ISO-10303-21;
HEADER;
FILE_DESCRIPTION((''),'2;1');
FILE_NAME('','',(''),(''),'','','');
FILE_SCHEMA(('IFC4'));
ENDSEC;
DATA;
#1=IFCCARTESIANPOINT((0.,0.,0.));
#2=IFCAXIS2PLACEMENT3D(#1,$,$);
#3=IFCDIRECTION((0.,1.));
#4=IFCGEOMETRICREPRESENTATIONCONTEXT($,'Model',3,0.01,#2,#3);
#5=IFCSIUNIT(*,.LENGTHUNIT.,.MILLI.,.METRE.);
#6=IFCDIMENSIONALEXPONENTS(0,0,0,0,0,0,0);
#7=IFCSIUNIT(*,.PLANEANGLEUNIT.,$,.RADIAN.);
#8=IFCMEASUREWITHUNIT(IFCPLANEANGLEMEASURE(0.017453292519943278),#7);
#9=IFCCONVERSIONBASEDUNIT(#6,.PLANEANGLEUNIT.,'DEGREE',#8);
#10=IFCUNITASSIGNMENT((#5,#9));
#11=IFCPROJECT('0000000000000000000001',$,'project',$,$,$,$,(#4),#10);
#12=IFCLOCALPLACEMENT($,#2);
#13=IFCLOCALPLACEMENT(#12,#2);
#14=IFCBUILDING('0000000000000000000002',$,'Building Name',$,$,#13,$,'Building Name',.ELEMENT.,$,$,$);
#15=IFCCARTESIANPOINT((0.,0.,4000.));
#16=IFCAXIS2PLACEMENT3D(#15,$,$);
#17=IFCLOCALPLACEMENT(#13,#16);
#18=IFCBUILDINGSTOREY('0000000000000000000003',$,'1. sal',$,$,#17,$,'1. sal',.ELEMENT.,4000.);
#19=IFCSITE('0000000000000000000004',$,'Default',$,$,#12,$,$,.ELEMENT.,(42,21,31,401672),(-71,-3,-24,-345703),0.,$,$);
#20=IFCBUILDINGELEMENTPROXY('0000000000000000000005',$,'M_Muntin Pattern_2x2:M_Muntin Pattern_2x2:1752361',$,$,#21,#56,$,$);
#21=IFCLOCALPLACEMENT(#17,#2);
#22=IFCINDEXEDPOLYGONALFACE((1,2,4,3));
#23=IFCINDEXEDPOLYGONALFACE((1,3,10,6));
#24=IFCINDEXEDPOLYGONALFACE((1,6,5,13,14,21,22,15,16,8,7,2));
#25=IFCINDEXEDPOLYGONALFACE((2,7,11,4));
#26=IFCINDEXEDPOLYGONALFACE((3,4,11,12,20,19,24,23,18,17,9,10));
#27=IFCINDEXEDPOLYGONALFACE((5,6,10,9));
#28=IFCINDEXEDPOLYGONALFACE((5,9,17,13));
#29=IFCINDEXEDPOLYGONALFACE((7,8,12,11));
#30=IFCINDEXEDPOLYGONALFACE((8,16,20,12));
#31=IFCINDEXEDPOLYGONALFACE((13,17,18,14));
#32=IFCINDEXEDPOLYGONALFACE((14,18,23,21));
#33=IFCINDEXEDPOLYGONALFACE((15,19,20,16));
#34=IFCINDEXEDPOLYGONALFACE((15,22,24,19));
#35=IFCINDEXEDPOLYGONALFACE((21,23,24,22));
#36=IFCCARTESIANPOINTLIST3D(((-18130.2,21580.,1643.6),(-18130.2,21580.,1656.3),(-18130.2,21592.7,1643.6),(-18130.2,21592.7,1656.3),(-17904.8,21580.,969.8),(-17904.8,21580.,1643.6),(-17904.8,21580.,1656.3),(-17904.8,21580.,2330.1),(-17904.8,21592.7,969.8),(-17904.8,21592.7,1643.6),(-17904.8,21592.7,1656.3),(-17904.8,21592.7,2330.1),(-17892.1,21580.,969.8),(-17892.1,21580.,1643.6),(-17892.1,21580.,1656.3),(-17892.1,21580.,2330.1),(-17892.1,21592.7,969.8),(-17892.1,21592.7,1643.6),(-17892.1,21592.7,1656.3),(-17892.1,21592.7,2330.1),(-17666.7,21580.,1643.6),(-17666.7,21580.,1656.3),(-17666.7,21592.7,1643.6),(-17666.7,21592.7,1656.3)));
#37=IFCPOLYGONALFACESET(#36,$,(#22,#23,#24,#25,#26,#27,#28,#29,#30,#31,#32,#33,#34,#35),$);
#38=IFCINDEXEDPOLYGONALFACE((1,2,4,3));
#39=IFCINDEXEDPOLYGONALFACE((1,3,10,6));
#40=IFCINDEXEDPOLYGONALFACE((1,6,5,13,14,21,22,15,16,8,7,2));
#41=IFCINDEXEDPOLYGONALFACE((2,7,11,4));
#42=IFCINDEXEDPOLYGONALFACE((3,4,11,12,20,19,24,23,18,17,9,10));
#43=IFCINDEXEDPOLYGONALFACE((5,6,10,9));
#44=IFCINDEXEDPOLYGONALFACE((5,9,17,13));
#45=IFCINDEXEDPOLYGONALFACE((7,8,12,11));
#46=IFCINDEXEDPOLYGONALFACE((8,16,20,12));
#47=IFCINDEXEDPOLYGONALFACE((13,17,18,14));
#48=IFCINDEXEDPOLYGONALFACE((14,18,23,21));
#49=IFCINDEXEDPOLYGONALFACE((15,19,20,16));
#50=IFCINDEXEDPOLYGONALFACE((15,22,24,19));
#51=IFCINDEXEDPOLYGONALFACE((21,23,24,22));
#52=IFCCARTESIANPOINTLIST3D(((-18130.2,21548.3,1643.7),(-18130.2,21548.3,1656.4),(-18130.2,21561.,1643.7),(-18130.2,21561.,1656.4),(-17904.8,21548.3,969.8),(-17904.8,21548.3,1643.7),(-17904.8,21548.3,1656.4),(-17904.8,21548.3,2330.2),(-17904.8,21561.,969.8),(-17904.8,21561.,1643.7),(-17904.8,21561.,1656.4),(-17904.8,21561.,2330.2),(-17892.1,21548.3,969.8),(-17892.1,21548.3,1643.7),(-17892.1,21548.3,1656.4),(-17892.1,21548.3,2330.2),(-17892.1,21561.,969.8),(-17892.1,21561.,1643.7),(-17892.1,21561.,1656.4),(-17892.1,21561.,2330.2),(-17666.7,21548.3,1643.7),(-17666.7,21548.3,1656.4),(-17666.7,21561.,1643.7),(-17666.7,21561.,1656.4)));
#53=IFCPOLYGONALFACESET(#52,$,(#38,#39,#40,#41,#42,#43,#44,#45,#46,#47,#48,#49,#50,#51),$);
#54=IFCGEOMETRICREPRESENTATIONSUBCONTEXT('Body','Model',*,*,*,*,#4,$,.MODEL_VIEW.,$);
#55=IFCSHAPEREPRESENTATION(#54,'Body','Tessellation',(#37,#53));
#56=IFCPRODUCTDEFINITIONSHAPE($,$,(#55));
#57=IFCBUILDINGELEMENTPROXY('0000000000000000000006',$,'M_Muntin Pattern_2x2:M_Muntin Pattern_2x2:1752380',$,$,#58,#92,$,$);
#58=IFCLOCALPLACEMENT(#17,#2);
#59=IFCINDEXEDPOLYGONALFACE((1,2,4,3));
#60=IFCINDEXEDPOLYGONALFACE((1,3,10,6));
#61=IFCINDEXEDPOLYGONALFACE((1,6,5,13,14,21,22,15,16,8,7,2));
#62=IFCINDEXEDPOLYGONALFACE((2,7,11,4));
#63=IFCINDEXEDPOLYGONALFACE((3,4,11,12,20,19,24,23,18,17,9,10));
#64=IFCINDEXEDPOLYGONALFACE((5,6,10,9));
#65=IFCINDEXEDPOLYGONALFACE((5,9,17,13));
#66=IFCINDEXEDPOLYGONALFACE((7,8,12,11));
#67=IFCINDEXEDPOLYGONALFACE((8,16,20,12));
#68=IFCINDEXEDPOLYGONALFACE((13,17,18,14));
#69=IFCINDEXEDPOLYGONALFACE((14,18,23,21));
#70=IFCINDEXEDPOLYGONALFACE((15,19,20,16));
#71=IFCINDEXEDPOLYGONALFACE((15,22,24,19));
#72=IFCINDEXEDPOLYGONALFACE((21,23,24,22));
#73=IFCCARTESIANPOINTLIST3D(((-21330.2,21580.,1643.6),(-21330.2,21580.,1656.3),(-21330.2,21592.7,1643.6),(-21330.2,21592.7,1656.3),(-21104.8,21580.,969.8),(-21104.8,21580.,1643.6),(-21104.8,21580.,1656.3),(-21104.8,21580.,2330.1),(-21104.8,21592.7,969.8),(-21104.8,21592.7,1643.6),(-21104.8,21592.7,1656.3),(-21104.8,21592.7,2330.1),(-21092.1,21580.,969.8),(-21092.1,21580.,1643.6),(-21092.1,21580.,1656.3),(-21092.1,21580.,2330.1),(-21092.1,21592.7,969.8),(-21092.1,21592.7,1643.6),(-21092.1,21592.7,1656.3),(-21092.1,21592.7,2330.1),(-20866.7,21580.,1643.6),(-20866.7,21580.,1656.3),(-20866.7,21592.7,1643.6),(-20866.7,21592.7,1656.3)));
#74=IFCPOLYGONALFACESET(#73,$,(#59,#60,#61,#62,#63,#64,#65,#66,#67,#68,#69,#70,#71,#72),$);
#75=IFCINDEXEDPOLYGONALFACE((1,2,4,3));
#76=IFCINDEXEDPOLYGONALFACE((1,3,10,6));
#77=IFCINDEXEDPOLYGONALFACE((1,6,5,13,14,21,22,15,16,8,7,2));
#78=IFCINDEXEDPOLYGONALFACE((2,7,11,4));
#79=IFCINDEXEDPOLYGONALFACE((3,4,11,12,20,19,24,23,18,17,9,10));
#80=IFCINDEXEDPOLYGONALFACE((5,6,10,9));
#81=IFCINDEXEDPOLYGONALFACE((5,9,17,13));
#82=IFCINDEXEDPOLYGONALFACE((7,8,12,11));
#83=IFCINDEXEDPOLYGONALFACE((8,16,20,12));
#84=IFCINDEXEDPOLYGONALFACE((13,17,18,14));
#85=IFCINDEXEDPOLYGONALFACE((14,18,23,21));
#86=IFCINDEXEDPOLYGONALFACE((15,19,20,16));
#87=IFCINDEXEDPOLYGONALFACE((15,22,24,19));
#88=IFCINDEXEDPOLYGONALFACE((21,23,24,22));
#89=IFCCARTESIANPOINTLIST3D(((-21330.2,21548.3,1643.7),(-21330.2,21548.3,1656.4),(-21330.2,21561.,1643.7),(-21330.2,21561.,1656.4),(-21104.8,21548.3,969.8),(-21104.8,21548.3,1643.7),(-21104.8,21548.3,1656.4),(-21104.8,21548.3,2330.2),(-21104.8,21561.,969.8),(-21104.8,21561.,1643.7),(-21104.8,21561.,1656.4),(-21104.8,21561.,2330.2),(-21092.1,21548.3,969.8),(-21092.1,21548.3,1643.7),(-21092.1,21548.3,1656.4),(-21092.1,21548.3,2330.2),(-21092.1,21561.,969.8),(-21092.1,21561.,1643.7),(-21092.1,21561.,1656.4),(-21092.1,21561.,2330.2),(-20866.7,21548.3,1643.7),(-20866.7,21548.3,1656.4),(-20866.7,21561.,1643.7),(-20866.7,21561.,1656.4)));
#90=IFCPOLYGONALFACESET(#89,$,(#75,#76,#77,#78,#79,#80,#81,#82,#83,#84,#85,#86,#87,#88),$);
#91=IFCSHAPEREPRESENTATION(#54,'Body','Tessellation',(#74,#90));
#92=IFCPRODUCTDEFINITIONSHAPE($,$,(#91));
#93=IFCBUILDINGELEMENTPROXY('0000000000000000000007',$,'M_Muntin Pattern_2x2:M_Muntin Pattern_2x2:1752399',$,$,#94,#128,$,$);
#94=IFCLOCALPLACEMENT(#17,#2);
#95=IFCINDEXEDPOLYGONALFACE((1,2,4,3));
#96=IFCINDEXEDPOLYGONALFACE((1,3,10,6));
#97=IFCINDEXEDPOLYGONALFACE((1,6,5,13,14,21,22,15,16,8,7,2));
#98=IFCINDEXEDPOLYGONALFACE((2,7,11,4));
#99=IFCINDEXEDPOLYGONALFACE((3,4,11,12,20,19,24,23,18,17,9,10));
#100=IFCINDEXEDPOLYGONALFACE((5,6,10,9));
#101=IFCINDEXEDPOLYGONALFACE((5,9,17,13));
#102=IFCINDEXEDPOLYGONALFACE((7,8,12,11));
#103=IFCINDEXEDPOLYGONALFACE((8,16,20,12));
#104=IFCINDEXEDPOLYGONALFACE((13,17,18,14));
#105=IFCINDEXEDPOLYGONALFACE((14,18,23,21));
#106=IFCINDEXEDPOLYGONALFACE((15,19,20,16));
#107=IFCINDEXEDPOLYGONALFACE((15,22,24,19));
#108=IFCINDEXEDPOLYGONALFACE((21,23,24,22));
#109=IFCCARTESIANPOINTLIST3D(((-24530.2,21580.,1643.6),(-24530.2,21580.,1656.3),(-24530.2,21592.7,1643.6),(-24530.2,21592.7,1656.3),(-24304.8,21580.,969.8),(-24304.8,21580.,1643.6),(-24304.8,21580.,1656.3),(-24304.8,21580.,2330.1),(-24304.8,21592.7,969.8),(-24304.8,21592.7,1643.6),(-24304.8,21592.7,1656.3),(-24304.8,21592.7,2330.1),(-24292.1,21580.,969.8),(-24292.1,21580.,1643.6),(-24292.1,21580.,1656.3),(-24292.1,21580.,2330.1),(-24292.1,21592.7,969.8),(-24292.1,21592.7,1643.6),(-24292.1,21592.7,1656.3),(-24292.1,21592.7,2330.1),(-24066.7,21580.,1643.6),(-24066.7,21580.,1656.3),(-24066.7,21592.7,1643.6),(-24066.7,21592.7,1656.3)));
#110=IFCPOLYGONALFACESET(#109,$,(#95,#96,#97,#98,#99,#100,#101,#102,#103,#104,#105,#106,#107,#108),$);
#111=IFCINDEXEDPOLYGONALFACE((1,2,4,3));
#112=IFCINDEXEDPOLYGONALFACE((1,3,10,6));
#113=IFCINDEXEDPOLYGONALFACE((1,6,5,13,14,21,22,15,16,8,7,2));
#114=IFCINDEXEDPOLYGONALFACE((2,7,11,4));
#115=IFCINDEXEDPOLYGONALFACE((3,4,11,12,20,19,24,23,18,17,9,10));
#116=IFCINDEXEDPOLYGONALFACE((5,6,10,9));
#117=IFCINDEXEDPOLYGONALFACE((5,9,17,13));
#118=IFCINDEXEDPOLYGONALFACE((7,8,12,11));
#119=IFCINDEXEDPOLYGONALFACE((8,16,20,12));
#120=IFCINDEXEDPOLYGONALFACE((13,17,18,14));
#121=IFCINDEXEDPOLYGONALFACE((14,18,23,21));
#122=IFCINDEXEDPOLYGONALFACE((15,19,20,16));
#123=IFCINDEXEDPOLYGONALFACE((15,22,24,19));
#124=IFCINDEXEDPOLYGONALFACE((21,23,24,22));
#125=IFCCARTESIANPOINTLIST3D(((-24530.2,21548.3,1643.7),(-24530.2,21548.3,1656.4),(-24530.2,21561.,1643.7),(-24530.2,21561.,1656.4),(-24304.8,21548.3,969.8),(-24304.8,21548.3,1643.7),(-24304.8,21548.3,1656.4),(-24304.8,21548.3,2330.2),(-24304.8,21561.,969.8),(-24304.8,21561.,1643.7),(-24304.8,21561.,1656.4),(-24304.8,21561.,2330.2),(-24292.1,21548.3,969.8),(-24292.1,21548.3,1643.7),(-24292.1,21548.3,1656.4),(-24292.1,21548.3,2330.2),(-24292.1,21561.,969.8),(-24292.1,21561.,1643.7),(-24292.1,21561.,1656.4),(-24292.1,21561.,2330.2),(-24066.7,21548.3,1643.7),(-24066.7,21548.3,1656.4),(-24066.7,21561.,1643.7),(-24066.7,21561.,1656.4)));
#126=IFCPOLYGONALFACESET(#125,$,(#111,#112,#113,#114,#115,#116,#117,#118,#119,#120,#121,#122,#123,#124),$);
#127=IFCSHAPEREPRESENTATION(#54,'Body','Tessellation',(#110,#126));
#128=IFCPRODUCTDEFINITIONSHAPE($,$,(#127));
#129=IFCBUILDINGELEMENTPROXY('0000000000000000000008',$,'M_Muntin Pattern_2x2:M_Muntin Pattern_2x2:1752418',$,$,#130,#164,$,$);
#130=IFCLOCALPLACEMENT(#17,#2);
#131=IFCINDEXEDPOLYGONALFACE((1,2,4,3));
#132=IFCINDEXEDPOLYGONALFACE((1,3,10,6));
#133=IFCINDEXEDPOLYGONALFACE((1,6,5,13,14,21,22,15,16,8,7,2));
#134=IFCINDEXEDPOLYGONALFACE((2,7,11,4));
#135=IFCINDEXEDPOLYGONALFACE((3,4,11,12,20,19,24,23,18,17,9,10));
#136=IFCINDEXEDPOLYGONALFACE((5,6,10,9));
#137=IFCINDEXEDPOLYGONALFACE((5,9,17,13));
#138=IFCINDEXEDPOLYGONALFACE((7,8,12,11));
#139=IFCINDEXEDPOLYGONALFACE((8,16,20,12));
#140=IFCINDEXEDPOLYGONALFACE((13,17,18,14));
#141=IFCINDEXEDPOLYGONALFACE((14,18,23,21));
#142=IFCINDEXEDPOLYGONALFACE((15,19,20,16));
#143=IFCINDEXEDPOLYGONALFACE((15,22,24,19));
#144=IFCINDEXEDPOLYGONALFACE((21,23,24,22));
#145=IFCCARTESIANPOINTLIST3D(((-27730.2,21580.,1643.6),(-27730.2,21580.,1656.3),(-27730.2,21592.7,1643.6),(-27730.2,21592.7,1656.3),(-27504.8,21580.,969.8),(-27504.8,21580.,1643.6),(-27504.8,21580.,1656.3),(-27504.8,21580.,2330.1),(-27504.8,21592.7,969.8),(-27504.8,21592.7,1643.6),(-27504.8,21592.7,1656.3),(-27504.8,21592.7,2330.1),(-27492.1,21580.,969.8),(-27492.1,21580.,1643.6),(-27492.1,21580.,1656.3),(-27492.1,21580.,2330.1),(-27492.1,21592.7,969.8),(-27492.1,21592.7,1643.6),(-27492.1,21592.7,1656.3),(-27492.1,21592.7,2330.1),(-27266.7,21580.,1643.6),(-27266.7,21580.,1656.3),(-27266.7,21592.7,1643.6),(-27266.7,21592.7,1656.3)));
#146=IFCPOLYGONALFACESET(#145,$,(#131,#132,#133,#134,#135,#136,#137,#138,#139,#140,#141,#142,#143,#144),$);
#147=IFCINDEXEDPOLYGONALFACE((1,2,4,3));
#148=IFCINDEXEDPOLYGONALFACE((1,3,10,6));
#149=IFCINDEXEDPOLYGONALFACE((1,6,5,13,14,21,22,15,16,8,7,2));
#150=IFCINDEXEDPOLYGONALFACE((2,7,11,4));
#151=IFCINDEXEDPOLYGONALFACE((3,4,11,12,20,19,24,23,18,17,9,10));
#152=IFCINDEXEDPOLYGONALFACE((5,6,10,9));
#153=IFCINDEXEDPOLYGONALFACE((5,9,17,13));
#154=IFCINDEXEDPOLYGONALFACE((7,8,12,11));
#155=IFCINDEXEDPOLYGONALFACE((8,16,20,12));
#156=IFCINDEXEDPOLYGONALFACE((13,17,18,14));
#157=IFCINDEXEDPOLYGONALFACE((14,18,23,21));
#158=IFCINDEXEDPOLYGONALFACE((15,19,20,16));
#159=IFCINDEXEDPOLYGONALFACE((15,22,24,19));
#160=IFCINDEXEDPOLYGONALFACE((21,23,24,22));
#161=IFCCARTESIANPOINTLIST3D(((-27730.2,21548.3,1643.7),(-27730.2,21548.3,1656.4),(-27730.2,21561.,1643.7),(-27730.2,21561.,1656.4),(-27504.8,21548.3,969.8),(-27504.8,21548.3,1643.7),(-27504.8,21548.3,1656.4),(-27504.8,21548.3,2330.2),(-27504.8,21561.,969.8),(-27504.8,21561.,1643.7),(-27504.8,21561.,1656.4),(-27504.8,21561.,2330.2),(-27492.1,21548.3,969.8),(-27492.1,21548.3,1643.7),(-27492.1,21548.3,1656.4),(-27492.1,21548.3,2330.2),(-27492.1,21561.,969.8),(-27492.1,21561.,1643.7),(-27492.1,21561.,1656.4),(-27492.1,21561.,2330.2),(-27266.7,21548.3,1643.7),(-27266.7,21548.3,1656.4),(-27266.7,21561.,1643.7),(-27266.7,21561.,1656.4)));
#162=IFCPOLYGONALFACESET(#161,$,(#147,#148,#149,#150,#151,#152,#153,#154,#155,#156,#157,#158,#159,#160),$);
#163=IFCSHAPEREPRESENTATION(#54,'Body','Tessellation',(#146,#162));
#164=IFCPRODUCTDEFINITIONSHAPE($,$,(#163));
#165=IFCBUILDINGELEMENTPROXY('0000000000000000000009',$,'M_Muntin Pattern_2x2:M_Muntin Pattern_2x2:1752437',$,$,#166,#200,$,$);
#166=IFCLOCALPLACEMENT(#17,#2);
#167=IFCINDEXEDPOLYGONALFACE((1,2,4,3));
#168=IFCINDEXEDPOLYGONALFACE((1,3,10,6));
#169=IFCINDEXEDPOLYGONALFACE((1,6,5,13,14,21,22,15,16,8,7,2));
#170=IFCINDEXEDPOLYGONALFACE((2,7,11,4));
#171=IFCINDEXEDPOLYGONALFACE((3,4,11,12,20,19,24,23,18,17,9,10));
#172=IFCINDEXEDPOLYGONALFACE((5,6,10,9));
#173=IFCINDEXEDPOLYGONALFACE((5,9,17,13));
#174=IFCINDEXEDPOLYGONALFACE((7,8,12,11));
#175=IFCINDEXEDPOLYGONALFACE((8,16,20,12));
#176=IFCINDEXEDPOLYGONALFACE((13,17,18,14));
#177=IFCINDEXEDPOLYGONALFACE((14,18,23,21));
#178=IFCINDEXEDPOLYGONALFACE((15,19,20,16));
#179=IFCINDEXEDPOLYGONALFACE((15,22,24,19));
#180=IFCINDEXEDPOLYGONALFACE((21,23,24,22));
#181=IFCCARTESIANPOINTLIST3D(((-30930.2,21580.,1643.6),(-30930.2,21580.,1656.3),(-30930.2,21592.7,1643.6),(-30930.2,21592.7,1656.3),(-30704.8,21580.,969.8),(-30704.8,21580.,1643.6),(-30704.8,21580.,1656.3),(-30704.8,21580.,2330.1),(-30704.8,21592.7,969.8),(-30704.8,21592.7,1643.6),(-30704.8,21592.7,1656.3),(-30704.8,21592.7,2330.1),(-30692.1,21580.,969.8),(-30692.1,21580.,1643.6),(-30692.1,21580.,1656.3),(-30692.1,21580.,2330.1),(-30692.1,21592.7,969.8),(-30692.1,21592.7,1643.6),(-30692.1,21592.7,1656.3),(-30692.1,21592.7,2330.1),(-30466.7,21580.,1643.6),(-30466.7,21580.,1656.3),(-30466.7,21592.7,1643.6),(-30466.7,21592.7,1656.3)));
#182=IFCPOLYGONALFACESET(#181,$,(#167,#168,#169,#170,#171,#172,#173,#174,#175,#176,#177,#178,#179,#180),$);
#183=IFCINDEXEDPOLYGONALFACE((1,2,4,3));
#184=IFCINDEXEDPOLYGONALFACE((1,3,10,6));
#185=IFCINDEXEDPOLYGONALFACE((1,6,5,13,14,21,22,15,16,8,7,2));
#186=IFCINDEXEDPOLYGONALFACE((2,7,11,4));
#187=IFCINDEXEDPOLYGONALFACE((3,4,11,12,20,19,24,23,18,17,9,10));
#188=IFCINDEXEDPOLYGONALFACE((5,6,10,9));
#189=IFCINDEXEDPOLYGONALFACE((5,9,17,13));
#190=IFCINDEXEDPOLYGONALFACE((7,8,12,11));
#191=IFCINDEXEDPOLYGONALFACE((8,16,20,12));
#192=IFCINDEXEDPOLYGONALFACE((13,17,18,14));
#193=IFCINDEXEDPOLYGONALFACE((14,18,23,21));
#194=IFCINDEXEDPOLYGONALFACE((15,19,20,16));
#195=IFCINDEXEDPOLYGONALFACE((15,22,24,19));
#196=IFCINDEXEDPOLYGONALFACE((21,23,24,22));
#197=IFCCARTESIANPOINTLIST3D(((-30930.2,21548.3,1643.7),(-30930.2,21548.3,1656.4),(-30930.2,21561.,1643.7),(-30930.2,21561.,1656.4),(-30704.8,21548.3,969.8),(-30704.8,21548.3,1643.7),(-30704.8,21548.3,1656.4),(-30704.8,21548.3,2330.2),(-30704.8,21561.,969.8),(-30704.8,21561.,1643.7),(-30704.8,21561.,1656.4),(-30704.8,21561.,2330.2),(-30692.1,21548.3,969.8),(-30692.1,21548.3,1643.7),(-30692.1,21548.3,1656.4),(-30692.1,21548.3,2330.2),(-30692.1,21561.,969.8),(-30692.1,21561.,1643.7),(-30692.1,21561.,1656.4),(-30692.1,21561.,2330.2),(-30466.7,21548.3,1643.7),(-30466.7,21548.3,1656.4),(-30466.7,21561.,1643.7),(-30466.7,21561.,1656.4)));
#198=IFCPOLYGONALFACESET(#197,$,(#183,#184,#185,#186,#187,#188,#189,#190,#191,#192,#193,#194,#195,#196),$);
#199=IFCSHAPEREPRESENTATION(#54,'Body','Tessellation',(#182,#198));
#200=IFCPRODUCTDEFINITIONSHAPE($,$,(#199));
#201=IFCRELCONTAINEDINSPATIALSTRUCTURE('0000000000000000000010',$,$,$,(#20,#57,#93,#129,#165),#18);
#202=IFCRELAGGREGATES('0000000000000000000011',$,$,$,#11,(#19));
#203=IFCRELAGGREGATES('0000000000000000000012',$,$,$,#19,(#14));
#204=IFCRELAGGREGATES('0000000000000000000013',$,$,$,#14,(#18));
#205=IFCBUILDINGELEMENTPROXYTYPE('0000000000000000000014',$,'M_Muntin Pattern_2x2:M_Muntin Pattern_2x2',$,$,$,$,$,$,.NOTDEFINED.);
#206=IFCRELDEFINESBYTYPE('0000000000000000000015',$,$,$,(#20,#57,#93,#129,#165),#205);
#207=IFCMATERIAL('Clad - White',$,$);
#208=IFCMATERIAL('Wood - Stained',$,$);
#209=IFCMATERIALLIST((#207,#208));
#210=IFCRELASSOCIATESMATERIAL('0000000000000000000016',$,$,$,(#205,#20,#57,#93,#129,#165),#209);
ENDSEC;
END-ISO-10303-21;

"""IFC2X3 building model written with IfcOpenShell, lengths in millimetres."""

from ifc_helpers import new_model, entity, si_unit, converted_unit, direction, frame, origin, place, context, subcontext, project, spatial, polyline, outline, extrude, source, transform, mapped, material, material_list, type_object, type_shapes, element, save


model = new_model("IFC2X3")

# Units and contexts
model_context = context("Model", 3, precision=0.01, world=origin(), true_north=direction((0.0, 1.0)))
body_context = subcontext(model_context, "Body", "Model", "MODEL_VIEW")
ifc_project = project(units=[si_unit("LENGTHUNIT", "METRE", prefix="MILLI"), converted_unit("PLANEANGLEUNIT", "DEGREE", entity("IfcPlaneAngleMeasure", 0.017453292519943278), si_unit("PLANEANGLEUNIT", "RADIAN"), dimensions=[0, 0, 0, 0, 0, 0, 0])], contexts=[model_context])

# Site, building, storey
site_placement = place(None, origin())
site = spatial("IfcSite", under=ifc_project, at=site_placement, Name="Default", CompositionType="ELEMENT", RefLatitude=(42, 21, 31, 401672), RefLongitude=(-71, -3, -24, -345703), RefElevation=0.0)
building_placement = place(site_placement, origin())
building = spatial("IfcBuilding", under=site, at=building_placement, Name="Building Name", LongName="Building Name", CompositionType="ELEMENT")
storey_placement = place(building_placement, frame((0.0, 0.0, 4000.0)))
storey = spatial("IfcBuildingStorey", under=building, at=storey_placement, Name="1. sal", LongName="1. sal", CompositionType="ELEMENT", Elevation=4000.0)

# Building element proxies
ifc_material_1 = material(Name="Clad - White")
ifc_material_2 = material(Name="Wood - Stained")
ifc_material_list = material_list([ifc_material_1, ifc_material_2])
building_element_proxy_type_1 = type_object("IfcBuildingElementProxyType", Name="M_Muntin Pattern_2x2:M_Muntin Pattern_2x2", PredefinedType="NOTDEFINED", material=ifc_material_list)
shared_shape_1 = source(origin(), body_context, "Body", "SweptSolid", [
    extrude(outline(polyline([(6.4, -6.4), (680.1, -6.4), (680.1, 6.3), (6.4, 6.3), (6.4, 231.7), (-6.3, 231.7), (-6.3, 6.3), (-680.2, 6.3), (-680.2, -6.4), (-6.3, -6.4), (-6.3, -231.7), (6.4, -231.7), (6.4, -6.4)])), frame((0.0, 9.5, 680.1), z_axis=(0.0, 1.0, 0.0), x_axis=(0.0, 0.0, 1.0)), (0.0, 0.0, 1.0), 12.7),
    extrude(outline(polyline([(6.4, -6.4), (680.2, -6.4), (680.2, 6.3), (6.4, 6.3), (6.4, 231.7), (-6.3, 231.7), (-6.3, 6.3), (-680.2, 6.3), (-680.2, -6.4), (-6.3, -6.4), (-6.3, -231.7), (6.4, -231.7), (6.4, -6.4)])), frame((0.0, -22.2, 680.2), z_axis=(0.0, 1.0, 0.0), x_axis=(0.0, 0.0, 1.0)), (0.0, 0.0, 1.0), 12.7),
])
type_shapes(building_element_proxy_type_1, [shared_shape_1])
for number, where, name in (
    (1, (-17898.4, 21570.5, 969.8), "M_Muntin Pattern_2x2:M_Muntin Pattern_2x2:1752361"),
    (2, (-21098.4, 21570.5, 969.8), "M_Muntin Pattern_2x2:M_Muntin Pattern_2x2:1752380"),
    (3, (-24298.4, 21570.5, 969.8), "M_Muntin Pattern_2x2:M_Muntin Pattern_2x2:1752399"),
    (4, (-27498.4, 21570.5, 969.8), "M_Muntin Pattern_2x2:M_Muntin Pattern_2x2:1752418"),
    (5, (-30698.4, 21570.5, 969.8), "M_Muntin Pattern_2x2:M_Muntin Pattern_2x2:1752437"),
):
    element("IfcBuildingElementProxy", number, at=place(storey_placement, frame(where)), inside=storey, type_object=building_element_proxy_type_1, material=ifc_material_list, Name=name, context=body_context, shape_type="MappedRepresentation", body=[
        mapped(shared_shape_1, transform((0.0, 0.0, 0.0), scale=1.0)),
    ])

save(model, "model.ifc")
